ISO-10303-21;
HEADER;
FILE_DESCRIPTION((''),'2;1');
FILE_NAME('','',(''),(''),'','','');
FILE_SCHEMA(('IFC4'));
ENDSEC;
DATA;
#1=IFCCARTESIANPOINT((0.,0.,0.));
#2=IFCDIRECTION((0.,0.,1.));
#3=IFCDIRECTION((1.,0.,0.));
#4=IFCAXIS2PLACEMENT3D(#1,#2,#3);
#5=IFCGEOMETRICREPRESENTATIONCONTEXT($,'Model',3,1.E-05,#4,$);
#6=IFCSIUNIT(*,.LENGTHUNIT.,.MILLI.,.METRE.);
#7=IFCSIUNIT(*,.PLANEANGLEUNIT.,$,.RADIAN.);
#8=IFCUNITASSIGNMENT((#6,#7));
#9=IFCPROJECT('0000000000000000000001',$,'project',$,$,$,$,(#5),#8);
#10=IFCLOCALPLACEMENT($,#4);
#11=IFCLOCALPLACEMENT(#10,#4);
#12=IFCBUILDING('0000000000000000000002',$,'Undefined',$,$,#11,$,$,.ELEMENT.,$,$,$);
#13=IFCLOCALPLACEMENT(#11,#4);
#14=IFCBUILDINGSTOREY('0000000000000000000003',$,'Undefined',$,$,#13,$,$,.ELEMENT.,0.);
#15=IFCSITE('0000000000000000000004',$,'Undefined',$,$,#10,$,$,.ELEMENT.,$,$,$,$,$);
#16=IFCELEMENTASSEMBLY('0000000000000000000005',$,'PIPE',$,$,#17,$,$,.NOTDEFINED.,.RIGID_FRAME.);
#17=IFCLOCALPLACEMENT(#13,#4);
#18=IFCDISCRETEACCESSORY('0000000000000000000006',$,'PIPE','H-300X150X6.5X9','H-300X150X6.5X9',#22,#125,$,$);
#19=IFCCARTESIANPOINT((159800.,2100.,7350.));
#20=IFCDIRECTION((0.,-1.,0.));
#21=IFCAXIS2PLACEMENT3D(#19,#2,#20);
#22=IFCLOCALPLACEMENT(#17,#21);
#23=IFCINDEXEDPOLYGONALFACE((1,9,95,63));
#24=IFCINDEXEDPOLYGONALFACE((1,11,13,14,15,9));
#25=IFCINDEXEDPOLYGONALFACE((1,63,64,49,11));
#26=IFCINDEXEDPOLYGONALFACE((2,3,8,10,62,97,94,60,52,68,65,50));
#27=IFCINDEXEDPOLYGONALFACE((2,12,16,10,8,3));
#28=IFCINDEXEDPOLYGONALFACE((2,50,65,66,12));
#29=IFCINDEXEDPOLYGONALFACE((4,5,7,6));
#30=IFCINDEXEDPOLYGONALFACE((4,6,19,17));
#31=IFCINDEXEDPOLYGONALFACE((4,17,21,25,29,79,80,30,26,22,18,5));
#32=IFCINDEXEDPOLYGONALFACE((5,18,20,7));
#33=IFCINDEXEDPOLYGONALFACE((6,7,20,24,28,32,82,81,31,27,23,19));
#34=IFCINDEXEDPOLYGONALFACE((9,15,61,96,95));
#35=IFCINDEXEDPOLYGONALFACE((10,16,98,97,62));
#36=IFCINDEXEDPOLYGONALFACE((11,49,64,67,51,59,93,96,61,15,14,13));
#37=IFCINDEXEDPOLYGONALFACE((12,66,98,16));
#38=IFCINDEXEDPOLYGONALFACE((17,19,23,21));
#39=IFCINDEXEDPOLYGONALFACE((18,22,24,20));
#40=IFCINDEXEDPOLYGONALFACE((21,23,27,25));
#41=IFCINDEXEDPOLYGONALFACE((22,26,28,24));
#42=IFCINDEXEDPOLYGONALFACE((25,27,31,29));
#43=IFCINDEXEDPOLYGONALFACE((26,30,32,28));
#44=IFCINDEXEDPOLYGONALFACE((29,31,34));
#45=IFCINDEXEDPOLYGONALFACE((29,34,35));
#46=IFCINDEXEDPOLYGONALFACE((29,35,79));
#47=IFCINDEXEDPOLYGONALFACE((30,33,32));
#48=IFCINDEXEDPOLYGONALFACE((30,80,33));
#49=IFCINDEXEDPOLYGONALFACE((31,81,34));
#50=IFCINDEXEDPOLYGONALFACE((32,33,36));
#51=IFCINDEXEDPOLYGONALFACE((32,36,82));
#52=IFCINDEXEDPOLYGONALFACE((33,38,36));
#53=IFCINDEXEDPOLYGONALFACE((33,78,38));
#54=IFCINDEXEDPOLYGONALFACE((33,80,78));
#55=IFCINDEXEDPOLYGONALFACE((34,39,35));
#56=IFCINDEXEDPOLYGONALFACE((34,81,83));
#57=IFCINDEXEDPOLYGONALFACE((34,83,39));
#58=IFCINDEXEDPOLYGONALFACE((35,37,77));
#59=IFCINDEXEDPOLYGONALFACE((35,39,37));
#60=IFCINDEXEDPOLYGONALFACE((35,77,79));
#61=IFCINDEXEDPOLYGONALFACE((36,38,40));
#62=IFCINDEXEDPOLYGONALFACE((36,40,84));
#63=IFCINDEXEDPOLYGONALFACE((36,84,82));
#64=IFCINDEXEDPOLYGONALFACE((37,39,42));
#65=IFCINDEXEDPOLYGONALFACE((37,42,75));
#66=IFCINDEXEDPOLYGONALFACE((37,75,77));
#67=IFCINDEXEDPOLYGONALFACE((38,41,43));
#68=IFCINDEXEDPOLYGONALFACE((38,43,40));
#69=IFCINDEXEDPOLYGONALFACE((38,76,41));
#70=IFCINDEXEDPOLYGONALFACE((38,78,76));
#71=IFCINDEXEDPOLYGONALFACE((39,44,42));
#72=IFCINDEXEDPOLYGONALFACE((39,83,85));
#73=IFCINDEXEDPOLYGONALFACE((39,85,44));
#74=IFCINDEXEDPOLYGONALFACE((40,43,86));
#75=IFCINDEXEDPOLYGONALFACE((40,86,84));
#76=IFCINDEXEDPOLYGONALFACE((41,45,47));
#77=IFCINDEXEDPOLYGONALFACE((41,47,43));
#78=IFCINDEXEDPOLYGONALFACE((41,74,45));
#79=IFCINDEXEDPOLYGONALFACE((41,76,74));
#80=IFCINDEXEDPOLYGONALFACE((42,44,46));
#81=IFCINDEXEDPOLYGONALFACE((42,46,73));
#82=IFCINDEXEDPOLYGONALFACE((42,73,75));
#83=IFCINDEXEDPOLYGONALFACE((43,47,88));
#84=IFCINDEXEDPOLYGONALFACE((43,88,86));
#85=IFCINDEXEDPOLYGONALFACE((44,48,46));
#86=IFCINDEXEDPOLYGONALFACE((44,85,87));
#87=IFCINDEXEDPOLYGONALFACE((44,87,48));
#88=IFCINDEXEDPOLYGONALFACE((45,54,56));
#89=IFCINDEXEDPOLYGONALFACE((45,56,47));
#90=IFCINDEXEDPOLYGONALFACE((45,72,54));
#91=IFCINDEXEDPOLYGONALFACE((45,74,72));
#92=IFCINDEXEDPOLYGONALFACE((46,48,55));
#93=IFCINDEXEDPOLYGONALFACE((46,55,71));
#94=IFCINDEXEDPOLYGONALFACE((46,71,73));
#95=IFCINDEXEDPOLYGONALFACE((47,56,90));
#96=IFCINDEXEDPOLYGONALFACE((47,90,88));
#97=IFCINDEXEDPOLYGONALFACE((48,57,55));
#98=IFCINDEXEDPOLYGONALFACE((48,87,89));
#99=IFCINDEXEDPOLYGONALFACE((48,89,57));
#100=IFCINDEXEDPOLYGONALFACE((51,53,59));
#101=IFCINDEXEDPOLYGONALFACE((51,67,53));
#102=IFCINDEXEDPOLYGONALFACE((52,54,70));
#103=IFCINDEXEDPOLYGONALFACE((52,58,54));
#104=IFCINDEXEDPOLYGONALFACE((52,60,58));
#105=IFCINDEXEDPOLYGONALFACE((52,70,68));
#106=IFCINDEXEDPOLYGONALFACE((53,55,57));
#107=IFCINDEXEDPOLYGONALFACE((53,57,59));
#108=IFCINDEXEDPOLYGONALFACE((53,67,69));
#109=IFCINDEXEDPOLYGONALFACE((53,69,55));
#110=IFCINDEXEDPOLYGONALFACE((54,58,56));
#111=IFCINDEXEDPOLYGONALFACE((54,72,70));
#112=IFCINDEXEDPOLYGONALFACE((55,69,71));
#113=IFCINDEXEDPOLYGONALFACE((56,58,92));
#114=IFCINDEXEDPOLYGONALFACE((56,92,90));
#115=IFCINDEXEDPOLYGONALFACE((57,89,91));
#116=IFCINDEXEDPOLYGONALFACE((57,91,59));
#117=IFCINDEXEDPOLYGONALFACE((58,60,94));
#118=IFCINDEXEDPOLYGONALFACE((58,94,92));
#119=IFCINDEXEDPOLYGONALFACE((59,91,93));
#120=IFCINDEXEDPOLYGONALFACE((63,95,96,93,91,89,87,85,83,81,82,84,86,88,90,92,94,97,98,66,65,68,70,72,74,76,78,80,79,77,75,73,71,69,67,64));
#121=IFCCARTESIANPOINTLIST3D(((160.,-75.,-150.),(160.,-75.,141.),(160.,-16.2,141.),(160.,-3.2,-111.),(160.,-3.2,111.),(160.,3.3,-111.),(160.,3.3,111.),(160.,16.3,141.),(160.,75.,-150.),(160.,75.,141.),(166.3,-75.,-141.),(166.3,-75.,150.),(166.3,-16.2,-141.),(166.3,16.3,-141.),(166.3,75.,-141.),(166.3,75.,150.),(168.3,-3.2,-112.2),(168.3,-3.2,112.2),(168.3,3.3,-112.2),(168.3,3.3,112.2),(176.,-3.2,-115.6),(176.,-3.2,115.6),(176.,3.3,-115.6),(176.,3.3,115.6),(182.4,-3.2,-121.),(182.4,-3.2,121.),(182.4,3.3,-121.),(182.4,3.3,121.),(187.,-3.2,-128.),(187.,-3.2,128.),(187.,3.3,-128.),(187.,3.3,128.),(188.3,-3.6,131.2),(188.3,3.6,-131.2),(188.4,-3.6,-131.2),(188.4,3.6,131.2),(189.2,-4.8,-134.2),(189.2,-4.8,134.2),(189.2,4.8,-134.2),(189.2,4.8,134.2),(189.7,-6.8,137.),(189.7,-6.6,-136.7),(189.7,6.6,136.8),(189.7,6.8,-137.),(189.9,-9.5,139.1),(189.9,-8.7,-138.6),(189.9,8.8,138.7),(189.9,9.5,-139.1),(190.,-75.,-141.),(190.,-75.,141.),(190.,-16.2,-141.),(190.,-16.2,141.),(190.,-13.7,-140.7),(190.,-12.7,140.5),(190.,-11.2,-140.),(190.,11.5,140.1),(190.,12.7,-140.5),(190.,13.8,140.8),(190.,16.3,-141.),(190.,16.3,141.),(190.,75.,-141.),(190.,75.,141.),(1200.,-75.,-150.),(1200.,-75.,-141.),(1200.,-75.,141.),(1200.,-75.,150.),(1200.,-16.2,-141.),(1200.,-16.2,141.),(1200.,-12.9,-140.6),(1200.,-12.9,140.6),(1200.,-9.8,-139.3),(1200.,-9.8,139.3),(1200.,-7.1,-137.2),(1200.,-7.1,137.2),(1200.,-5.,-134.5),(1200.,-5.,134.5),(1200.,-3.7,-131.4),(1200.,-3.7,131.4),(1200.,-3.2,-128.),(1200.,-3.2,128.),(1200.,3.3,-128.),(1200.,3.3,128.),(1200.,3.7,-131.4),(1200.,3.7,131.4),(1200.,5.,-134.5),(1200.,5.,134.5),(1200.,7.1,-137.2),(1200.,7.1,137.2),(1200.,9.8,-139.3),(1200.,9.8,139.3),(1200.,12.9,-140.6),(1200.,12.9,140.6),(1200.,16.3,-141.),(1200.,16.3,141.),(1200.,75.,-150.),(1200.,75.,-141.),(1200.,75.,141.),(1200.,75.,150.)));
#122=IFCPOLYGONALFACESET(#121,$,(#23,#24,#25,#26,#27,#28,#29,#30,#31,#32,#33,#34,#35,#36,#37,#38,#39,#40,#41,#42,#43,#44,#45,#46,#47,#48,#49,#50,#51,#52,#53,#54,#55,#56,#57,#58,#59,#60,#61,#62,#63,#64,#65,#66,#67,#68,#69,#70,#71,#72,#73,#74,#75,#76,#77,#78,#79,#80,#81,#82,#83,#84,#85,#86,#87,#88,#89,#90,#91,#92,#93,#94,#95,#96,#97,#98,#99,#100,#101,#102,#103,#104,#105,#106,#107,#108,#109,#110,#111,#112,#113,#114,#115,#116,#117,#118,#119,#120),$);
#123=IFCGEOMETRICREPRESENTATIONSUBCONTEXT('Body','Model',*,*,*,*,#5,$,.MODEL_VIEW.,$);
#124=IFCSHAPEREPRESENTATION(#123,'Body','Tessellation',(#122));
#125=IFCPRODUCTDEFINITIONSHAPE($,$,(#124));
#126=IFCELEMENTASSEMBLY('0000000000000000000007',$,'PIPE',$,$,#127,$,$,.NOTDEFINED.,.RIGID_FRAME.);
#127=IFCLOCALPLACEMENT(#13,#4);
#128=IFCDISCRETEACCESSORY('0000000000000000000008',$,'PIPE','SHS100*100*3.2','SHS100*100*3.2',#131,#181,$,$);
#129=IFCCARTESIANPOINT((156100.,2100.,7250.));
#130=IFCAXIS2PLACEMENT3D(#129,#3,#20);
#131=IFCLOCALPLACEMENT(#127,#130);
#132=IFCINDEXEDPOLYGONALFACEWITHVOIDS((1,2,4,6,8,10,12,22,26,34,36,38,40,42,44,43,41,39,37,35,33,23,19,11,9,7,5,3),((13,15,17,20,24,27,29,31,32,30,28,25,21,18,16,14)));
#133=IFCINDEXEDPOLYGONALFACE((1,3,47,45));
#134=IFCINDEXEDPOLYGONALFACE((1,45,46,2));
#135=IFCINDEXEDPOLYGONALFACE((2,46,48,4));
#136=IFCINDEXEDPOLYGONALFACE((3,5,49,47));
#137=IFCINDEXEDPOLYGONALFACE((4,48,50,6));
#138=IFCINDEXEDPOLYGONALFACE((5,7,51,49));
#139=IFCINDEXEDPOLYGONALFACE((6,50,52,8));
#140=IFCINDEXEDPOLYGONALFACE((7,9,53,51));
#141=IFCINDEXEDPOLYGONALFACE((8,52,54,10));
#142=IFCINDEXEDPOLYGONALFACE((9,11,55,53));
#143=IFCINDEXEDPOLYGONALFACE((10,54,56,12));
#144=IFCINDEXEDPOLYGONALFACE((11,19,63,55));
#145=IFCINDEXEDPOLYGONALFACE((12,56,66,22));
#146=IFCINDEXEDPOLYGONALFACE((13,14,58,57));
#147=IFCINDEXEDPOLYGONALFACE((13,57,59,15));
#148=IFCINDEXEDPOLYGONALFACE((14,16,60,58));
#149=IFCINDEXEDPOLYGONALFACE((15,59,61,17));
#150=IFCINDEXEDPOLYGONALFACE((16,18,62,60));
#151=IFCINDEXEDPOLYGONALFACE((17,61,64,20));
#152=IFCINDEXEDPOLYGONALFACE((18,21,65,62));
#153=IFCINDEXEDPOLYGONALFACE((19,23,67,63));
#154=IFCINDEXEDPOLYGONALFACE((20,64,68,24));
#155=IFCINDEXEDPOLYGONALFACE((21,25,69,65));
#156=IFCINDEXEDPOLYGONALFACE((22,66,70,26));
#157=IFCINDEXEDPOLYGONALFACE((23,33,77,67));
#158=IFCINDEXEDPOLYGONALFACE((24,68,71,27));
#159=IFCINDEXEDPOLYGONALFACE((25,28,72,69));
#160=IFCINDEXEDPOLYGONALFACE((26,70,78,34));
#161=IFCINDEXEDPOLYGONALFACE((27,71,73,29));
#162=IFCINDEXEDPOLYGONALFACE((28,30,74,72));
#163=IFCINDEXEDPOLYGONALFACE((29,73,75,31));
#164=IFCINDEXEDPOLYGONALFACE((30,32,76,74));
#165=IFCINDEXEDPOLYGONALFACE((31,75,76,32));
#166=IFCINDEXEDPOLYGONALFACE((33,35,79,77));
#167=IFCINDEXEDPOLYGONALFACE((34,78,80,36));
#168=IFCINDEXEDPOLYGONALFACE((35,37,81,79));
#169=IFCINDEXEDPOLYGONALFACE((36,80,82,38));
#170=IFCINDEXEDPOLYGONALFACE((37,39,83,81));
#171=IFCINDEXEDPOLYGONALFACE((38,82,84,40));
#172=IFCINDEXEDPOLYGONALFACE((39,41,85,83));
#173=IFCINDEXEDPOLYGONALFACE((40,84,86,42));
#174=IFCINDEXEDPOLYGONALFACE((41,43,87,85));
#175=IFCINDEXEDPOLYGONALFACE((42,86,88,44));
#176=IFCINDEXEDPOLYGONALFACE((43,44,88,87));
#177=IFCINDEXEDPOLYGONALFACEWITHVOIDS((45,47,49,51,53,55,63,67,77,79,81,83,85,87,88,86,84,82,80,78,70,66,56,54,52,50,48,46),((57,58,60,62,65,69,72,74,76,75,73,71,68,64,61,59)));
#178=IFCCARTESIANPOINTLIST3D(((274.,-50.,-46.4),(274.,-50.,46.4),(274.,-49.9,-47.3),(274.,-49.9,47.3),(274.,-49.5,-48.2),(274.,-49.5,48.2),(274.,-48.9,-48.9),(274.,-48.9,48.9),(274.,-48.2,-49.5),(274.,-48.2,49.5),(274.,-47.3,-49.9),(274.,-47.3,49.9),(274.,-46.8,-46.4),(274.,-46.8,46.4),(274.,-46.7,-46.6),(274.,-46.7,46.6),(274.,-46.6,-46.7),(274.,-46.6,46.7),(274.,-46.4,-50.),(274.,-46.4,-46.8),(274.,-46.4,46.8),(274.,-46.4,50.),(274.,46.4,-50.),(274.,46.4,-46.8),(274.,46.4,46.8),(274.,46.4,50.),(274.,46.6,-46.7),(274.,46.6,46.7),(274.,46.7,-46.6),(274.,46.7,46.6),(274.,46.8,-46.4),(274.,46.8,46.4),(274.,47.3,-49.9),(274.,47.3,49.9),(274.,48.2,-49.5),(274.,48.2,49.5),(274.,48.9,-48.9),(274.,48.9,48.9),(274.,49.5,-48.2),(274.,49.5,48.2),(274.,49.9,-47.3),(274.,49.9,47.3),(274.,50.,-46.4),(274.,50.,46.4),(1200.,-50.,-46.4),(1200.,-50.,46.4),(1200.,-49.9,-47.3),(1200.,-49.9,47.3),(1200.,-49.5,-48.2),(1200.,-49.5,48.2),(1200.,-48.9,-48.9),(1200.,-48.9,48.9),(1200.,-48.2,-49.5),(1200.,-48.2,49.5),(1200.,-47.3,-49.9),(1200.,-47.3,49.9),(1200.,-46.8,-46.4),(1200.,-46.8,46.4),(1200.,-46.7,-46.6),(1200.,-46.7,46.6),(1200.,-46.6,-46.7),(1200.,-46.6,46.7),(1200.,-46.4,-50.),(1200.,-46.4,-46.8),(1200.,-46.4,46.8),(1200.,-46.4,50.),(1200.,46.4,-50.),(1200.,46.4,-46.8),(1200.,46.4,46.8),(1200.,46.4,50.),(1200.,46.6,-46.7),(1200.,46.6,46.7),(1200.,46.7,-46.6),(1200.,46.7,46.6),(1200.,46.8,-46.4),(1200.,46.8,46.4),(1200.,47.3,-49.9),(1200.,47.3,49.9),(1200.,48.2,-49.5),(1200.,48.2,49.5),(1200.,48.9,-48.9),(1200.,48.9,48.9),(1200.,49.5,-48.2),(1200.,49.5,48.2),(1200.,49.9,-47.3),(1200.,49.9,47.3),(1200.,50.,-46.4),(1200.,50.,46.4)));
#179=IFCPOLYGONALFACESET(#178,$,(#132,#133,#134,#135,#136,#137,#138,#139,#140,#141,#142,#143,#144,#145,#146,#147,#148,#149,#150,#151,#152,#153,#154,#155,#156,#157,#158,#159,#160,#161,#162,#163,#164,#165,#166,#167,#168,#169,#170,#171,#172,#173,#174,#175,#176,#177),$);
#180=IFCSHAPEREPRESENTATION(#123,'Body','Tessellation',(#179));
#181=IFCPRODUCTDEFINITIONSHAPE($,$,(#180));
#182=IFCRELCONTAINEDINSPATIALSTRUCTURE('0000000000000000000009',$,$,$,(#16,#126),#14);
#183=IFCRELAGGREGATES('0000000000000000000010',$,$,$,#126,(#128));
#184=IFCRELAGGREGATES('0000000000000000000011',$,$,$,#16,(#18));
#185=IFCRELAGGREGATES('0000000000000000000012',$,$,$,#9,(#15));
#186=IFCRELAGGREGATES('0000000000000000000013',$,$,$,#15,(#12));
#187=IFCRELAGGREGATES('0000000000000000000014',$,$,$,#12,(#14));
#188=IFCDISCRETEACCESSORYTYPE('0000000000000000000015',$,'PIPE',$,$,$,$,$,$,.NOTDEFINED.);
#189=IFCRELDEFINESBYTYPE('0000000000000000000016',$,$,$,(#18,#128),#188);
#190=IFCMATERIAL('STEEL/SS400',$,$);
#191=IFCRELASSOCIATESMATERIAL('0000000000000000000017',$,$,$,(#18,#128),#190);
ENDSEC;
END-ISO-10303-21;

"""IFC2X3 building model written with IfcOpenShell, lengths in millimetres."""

from ifc_helpers import new_model, si_unit, frame, origin_with_axes, origin_2d_with_axis, place, context, subcontext, project, spatial, polyline, circle_curve, parameter, trimmed, segment, composite_curve, hollow_rectangle, i_section, outline, extrude, boolean, clip, halfspace, material, type_object, element, aggregate, save


model = new_model("IFC2X3")

# Units and contexts
model_context = context("Model", 3, precision=1e-05, world=origin_with_axes())
body_context = subcontext(model_context, "Body", "Model", "MODEL_VIEW")
ifc_project = project(units=[si_unit("LENGTHUNIT", "METRE", prefix="MILLI"), si_unit("PLANEANGLEUNIT", "RADIAN")], contexts=[model_context])

# Site, building, storey
site_placement = place(None, origin_with_axes())
site = spatial("IfcSite", under=ifc_project, at=site_placement, Name="Undefined", CompositionType="ELEMENT")
building_placement = place(site_placement, origin_with_axes())
building = spatial("IfcBuilding", under=site, at=building_placement, Name="Undefined", CompositionType="ELEMENT")
storey_placement = place(building_placement, origin_with_axes())
storey = spatial("IfcBuildingStorey", under=building, at=storey_placement, Name="Undefined", CompositionType="ELEMENT", Elevation=0.0)

# Shared definitions
ifc_material_1 = material(Name="STEEL/SS400")

# Element assembly, discrete accessory
assembly_1_placement = place(storey_placement, origin_with_axes())
assembly_1 = element("IfcElementAssembly", 1, at=assembly_1_placement, inside=storey, Name="PIPE", AssemblyPlace="NOTDEFINED", PredefinedType="RIGID_FRAME")
discrete_accessory_type_1 = type_object("IfcDiscreteAccessoryType", Name="PIPE")
discrete_accessory_1_placement = place(assembly_1_placement, frame((159800.0, 2100.0, 7350.0), z_axis=(0.0, 0.0, 1.0), x_axis=(0.0, -1.0, 0.0)))
discrete_accessory_1 = element("IfcDiscreteAccessory", 2, at=discrete_accessory_1_placement, type_object=discrete_accessory_type_1, material=ifc_material_1, Name="PIPE", Description="H-300X150X6.5X9", ObjectType="H-300X150X6.5X9", context=body_context, shape_type="CSG", body=[
    boolean("DIFFERENCE", boolean("DIFFERENCE", boolean("DIFFERENCE", boolean("DIFFERENCE", boolean("DIFFERENCE", extrude(i_section(OverallWidth=150.0, OverallDepth=300.0, WebThickness=6.5, FlangeThickness=9.0, FilletRadius=13.0, at=origin_2d_with_axis()), frame((1200.0, 0.0, 0.0), z_axis=(-1.0, 0.0, 0.0), x_axis=(0.0, -1.0, 0.0)), (0.0, 0.0, 1.0), 1040.0), extrude(outline(composite_curve([segment(polyline([(0.0, 0.0), (30.0, 0.0), (30.0, 0.0)]), True, "CONTINUOUS"), segment(trimmed(circle_curve(origin_2d_with_axis(), 30.0), [parameter(0.0)], [parameter(1.570796)], True, "PARAMETER"), True, "CONTINUOUS"), segment(polyline([(0.0, 30.0), (0.0, 30.0), (0.0, 0.0)]), True, "CONTINUOUS")], self_intersect=True)), frame((160.0, 77.5, 141.0), z_axis=(0.0, -1.0, 0.0), x_axis=(0.0, 0.0, -1.0)), (0.0, 0.0, 1.0), 155.0)), extrude(outline(composite_curve([segment(polyline([(0.0, 0.0), (30.0, 0.0), (30.0, 0.0)]), True, "CONTINUOUS"), segment(trimmed(circle_curve(origin_2d_with_axis(), 30.0), [parameter(0.0)], [parameter(1.570796)], True, "PARAMETER"), True, "CONTINUOUS"), segment(polyline([(0.0, 30.0), (0.0, 30.0), (0.0, 0.0)]), True, "CONTINUOUS")], self_intersect=True)), frame((160.0, -77.5, -141.0), z_axis=(0.0, 1.0, 0.0), x_axis=(0.0, 0.0, 1.0)), (0.0, 0.0, 1.0), 155.0)), extrude(outline(polyline([(0.0, 0.0), (11.3, 0.0), (5.0, 9.0), (5.0, 9.5), (0.0, 9.5), (0.0, 0.0)])), frame((155.0, -80.0, 150.0), z_axis=(0.0, 1.0, 0.0), x_axis=(1.0, 0.0, 0.0)), (0.0, 0.0, 1.0), 160.0)), extrude(outline(polyline([(0.0, 0.0), (11.3, 0.0), (5.0, 9.0), (5.0, 9.5), (0.0, 9.5), (0.0, 0.0)])), frame((155.0, -80.0, -141.0), z_axis=(0.0, 1.0, 0.0), x_axis=(1.0, 0.0, 0.0)), (0.0, 0.0, 1.0), 160.0)), halfspace(frame((160.0, 0.0, -150.0), z_axis=(1.0, 0.0, 0.0), x_axis=(0.0, -1.0, 0.0)), True)),
])

# Element assembly, discrete accessory
assembly_2_placement = place(storey_placement, origin_with_axes())
assembly_2 = element("IfcElementAssembly", 3, at=assembly_2_placement, inside=storey, Name="PIPE", AssemblyPlace="NOTDEFINED", PredefinedType="RIGID_FRAME")
discrete_accessory_2_placement = place(assembly_2_placement, frame((156100.0, 2100.0, 7250.0), z_axis=(1.0, 0.0, 0.0), x_axis=(0.0, -1.0, 0.0)))
discrete_accessory_2 = element("IfcDiscreteAccessory", 4, at=discrete_accessory_2_placement, type_object=discrete_accessory_type_1, material=ifc_material_1, Name="PIPE", Description="SHS100*100*3.2", ObjectType="SHS100*100*3.2", context=body_context, shape_type="Clipping", body=[
    clip(clip(extrude(hollow_rectangle(XDim=100.0, YDim=100.0, WallThickness=3.2, InnerFilletRadius=0.4, OuterFilletRadius=3.6, at=origin_2d_with_axis()), frame((1200.0, 0.0, 0.0), z_axis=(-1.0, 0.0, 0.0), x_axis=(0.0, -1.0, 0.0)), (0.0, 0.0, 1.0), 1200.0), halfspace(frame((274.0, 50.0, -50.0), z_axis=(-1.0, 0.0, 0.0), x_axis=(0.0, 0.0, 1.0)), False)), halfspace(frame((1200.0, 0.0, -50.0), z_axis=(-1.0, 0.0, 0.0), x_axis=(0.0, 1.0, 0.0)), True)),
])
aggregate(assembly_2, [discrete_accessory_2])

aggregate(assembly_1, [discrete_accessory_1])

save(model, "model.ifc")
